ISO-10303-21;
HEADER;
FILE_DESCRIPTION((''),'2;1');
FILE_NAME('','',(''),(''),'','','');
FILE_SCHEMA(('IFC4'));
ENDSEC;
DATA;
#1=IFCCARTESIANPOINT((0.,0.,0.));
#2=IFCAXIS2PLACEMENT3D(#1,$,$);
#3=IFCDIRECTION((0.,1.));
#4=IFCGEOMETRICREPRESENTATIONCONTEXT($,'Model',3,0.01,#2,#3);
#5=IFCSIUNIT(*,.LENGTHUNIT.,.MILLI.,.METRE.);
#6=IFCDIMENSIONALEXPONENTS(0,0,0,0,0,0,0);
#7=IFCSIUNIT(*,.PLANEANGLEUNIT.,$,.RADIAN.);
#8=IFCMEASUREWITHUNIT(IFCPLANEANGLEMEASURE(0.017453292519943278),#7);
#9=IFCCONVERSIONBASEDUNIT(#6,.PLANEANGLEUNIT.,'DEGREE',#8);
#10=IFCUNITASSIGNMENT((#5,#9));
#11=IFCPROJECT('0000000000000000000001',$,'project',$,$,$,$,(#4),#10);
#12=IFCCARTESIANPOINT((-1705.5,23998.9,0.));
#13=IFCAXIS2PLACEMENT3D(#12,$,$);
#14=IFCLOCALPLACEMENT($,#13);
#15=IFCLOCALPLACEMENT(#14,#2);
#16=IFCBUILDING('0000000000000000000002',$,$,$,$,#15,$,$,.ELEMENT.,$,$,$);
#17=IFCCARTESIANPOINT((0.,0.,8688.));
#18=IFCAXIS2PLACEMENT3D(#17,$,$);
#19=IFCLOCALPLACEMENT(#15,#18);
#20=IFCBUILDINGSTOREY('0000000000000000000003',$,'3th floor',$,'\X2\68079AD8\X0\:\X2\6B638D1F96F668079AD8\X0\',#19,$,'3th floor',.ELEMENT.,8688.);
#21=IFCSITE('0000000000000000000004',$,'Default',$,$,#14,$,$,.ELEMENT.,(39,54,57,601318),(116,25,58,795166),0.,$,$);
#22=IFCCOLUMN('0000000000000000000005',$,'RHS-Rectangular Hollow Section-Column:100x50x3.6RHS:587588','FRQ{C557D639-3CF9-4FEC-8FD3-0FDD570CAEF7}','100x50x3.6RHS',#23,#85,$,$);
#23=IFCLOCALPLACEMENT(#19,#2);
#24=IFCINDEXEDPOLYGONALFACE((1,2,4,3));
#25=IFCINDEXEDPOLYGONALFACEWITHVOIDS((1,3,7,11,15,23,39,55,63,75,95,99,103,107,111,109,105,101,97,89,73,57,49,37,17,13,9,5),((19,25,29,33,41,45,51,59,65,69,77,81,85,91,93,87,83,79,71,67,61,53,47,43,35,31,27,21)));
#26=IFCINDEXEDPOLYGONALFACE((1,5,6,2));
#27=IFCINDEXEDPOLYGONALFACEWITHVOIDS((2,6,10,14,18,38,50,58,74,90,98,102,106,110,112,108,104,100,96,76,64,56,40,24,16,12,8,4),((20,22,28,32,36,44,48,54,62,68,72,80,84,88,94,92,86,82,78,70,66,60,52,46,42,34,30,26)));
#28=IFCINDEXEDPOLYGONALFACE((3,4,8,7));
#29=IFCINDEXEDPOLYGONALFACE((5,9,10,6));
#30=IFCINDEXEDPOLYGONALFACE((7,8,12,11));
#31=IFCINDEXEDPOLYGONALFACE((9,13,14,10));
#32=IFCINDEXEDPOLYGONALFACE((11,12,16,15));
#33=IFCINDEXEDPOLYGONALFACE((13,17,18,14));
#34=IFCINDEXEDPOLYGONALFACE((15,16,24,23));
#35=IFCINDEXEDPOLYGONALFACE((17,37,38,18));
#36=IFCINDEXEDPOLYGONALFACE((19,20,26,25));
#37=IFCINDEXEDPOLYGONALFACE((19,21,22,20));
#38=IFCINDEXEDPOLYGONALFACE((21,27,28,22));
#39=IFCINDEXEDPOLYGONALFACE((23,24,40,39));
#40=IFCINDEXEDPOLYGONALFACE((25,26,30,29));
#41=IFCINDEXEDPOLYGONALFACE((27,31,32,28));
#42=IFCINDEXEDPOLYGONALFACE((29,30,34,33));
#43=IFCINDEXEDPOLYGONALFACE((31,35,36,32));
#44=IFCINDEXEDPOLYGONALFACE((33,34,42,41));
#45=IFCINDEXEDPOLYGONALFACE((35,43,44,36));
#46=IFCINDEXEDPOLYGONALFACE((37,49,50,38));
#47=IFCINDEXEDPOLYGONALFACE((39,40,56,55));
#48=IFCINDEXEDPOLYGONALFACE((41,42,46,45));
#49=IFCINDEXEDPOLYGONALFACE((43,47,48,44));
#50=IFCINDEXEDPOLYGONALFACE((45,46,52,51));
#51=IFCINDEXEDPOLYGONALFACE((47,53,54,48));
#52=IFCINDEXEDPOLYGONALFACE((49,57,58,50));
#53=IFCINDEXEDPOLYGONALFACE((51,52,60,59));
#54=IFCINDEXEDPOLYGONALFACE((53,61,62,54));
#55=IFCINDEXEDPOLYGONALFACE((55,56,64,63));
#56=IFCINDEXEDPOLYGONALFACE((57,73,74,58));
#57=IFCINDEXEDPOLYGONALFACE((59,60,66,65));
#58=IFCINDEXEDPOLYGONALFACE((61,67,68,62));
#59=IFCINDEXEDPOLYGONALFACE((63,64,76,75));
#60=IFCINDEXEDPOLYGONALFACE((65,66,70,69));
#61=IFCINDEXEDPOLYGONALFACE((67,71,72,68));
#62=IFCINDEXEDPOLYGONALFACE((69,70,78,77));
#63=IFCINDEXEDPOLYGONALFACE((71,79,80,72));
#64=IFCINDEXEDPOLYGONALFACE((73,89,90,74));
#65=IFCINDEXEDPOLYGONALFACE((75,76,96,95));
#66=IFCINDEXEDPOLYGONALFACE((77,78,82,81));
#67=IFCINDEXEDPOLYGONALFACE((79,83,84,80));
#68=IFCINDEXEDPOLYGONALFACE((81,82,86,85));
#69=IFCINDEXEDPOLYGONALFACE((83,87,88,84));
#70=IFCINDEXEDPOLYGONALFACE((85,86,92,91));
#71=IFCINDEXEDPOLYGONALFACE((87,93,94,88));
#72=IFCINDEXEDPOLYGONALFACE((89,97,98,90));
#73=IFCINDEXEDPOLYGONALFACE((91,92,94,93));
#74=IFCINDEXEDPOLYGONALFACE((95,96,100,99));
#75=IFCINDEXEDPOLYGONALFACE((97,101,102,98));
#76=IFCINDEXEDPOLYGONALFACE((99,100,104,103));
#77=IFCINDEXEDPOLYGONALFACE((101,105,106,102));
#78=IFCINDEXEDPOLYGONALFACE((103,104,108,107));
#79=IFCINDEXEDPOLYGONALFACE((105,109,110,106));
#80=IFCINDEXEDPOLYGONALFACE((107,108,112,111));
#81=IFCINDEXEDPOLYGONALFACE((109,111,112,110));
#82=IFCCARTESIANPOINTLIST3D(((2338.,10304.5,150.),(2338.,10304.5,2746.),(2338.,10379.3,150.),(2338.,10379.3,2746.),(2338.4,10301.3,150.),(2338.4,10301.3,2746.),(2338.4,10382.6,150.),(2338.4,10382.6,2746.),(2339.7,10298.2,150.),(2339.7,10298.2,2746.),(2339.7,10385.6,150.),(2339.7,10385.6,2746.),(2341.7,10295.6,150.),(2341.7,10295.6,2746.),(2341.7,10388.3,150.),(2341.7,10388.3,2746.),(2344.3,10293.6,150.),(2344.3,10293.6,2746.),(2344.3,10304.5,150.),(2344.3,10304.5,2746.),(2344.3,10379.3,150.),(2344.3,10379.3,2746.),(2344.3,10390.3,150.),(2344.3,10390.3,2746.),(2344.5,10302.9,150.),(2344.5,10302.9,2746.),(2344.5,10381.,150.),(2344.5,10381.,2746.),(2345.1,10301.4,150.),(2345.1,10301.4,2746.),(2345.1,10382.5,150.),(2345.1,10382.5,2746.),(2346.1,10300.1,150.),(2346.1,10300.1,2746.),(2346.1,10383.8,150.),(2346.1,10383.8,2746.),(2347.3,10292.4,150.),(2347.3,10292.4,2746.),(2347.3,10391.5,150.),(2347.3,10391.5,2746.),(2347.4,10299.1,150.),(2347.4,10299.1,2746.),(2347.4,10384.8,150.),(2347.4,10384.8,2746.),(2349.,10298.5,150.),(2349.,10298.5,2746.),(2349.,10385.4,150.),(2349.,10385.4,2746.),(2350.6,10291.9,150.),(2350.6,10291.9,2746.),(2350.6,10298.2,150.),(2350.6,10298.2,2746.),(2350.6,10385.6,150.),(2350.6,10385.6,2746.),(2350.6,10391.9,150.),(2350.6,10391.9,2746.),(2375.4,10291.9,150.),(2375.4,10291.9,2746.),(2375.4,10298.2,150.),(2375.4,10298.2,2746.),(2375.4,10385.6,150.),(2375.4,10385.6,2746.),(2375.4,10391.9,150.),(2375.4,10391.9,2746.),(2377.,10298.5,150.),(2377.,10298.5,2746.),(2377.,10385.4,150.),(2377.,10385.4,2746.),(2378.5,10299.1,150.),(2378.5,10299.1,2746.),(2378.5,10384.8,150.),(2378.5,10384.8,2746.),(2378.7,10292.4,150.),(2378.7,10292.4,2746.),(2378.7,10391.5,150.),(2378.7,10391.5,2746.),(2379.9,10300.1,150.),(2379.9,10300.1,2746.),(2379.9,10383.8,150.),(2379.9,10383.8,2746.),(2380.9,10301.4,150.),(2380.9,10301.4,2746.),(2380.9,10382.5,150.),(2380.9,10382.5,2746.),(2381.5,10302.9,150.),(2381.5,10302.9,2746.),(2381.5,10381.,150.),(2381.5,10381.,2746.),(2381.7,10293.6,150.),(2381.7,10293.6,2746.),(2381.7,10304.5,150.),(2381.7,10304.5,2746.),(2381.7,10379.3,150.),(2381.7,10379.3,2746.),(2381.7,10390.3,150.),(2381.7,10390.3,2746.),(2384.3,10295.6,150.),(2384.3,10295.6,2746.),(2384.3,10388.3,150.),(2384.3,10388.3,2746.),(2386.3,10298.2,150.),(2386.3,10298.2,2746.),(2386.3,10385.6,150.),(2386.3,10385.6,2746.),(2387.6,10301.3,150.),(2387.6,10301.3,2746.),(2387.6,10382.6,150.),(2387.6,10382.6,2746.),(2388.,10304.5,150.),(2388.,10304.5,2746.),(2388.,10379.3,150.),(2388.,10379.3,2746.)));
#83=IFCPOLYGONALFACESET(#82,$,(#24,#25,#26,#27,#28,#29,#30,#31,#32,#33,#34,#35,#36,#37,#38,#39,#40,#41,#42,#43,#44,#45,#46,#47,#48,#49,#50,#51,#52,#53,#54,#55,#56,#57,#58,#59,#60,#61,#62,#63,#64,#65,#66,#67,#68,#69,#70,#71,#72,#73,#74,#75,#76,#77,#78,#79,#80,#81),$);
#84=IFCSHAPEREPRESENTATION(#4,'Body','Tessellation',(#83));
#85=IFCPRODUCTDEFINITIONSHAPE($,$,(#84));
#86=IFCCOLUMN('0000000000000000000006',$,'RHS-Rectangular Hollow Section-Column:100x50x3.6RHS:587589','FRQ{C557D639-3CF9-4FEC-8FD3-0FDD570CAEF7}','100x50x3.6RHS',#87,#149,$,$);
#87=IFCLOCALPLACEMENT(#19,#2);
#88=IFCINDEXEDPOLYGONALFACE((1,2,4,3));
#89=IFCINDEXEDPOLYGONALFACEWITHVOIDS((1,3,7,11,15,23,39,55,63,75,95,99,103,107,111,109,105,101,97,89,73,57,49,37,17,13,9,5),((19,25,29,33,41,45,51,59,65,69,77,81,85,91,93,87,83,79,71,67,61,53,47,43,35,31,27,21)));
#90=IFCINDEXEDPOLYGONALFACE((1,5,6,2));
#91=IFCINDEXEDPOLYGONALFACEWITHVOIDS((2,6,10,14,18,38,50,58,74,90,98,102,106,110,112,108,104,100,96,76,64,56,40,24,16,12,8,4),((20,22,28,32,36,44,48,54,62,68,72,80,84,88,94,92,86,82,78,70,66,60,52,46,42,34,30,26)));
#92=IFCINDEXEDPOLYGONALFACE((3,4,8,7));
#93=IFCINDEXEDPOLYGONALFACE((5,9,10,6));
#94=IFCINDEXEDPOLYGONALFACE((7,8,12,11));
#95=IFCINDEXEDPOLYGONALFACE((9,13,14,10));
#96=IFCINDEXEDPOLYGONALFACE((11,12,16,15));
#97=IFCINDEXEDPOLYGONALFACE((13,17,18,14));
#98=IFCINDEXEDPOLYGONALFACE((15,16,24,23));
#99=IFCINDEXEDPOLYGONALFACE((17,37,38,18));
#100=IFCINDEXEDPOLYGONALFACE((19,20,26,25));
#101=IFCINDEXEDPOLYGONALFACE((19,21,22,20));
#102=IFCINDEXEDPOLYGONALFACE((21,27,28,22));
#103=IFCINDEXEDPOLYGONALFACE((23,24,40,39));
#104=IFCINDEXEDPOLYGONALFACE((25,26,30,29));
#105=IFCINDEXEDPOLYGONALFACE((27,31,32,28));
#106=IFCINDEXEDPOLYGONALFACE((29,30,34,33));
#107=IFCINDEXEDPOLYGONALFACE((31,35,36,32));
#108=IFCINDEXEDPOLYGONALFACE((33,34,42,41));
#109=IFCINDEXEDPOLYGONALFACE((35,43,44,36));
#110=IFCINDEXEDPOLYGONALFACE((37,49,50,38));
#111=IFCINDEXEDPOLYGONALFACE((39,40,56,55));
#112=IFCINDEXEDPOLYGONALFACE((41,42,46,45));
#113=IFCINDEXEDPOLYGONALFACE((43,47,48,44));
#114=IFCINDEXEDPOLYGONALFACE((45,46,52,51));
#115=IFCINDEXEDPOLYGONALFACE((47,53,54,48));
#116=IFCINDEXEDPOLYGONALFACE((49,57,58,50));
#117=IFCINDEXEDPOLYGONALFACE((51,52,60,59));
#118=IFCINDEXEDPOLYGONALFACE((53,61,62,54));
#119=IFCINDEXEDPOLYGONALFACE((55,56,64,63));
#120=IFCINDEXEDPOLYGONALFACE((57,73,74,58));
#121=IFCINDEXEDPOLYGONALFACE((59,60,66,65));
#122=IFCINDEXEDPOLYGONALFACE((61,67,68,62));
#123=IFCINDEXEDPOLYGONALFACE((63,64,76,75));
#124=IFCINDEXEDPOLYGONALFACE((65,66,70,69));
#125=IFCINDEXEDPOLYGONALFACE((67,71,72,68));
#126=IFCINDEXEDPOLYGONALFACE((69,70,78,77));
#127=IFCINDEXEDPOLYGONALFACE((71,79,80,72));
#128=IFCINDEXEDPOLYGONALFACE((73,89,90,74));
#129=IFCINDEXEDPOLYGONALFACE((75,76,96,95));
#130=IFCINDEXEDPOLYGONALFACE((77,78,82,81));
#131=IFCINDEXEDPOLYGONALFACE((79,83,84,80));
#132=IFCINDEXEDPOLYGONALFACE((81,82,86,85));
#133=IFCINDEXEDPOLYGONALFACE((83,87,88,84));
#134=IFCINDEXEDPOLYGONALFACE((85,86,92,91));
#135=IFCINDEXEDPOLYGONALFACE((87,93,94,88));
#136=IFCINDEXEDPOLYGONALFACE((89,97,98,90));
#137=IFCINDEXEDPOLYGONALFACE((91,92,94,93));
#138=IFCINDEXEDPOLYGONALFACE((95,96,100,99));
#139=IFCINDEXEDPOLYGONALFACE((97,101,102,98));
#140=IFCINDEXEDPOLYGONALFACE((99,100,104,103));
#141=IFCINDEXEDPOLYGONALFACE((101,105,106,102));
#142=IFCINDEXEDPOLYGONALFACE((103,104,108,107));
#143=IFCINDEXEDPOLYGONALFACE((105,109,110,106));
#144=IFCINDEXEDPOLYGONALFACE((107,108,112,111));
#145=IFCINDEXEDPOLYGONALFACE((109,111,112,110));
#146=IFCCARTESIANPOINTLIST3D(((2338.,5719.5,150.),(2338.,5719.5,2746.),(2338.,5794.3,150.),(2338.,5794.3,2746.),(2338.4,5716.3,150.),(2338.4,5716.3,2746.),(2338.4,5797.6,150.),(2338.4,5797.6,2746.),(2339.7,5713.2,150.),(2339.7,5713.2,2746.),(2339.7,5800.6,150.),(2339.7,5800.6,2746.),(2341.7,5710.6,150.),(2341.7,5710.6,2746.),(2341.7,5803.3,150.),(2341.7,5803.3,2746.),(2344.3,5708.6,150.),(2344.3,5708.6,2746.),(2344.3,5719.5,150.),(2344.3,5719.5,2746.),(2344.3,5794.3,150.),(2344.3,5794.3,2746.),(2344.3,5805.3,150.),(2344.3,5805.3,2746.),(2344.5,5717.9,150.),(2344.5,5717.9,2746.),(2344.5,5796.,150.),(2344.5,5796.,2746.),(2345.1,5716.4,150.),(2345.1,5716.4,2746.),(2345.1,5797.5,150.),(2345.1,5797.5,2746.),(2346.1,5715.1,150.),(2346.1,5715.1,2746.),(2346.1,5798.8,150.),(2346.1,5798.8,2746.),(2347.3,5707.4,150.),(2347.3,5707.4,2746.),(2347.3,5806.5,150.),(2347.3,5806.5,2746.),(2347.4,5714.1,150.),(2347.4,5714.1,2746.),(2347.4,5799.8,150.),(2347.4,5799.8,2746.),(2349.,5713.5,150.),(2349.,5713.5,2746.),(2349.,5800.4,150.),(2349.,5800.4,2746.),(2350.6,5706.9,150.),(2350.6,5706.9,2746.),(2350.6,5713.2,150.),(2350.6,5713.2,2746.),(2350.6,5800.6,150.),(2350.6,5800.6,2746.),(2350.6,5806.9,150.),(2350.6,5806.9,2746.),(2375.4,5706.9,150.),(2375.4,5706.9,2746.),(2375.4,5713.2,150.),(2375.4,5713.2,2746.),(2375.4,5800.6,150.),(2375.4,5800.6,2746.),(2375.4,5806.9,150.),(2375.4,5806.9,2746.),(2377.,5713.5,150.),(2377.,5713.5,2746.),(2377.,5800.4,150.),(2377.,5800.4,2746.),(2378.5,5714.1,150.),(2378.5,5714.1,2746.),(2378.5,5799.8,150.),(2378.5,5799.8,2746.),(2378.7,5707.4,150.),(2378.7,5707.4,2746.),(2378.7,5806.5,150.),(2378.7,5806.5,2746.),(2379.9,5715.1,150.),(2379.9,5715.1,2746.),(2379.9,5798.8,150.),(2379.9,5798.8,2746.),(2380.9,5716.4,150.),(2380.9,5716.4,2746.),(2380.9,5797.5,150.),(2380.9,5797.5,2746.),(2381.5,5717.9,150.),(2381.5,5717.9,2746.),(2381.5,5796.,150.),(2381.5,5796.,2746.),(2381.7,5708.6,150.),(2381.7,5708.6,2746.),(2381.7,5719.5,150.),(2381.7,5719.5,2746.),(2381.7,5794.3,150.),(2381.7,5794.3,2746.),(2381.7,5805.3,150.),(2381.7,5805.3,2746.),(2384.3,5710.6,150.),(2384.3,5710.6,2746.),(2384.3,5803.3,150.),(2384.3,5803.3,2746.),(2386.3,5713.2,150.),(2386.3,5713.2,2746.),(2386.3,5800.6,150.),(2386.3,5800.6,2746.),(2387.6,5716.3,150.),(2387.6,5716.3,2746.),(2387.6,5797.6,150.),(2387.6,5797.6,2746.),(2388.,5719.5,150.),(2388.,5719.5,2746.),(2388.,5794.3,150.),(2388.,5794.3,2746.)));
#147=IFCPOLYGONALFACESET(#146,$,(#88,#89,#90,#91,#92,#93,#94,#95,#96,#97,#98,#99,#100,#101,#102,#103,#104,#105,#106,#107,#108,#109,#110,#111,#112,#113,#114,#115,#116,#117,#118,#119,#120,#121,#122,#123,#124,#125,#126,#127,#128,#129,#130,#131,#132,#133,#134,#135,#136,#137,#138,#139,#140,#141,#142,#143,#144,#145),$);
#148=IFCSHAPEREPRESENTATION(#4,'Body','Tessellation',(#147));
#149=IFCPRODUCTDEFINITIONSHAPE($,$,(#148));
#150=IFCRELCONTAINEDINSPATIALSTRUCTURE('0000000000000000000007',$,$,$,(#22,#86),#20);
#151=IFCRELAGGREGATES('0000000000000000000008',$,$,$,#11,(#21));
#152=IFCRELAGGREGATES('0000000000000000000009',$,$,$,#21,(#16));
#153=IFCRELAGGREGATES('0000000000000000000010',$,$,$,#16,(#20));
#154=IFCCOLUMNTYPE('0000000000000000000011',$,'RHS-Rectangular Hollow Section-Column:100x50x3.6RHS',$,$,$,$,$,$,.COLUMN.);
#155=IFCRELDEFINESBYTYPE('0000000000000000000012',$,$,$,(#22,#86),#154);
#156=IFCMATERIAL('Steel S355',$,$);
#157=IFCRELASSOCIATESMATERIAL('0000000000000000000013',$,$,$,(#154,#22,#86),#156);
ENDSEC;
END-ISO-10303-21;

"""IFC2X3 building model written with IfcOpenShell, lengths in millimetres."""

from ifc_helpers import new_model, entity, si_unit, converted_unit, direction, frame, origin, origin_2d, place, context, project, spatial, hollow_rectangle, extrude, clip, halfspace, material, type_object, element, save


model = new_model("IFC2X3")

# Units and contexts
model_context = context("Model", 3, precision=0.01, world=origin(), true_north=direction((0.0, 1.0)))
ifc_project = project(units=[si_unit("LENGTHUNIT", "METRE", prefix="MILLI"), converted_unit("PLANEANGLEUNIT", "DEGREE", entity("IfcPlaneAngleMeasure", 0.017453292519943278), si_unit("PLANEANGLEUNIT", "RADIAN"), dimensions=[0, 0, 0, 0, 0, 0, 0])], contexts=[model_context])

# Site, building, storey
site_placement = place(None, frame((-1705.5, 23998.9, 0.0)))
site = spatial("IfcSite", under=ifc_project, at=site_placement, Name="Default", CompositionType="ELEMENT", RefLatitude=(39, 54, 57, 601318), RefLongitude=(116, 25, 58, 795166), RefElevation=0.0)
building_placement = place(site_placement, origin())
building = spatial("IfcBuilding", under=site, at=building_placement, CompositionType="ELEMENT")
storey_placement = place(building_placement, frame((0.0, 0.0, 8688.0)))
storey = spatial("IfcBuildingStorey", under=building, at=storey_placement, Name="3th floor", ObjectType="标高:正负零标高", LongName="3th floor", CompositionType="ELEMENT", Elevation=8688.0)

# Columns
ifc_material_1 = material(Name="Steel S355")
column_type_1 = type_object("IfcColumnType", Name="RHS-Rectangular Hollow Section-Column:100x50x3.6RHS", PredefinedType="COLUMN", material=ifc_material_1)
column_1_placement = place(storey_placement, frame((2363.0, 10341.9, 2746.0)))
element("IfcColumn", 1, at=column_1_placement, inside=storey, type_object=column_type_1, material=ifc_material_1, Name="RHS-Rectangular Hollow Section-Column:100x50x3.6RHS:587588", Description="FRQ{C557D639-3CF9-4FEC-8FD3-0FDD570CAEF7}", ObjectType="100x50x3.6RHS", context=model_context, shape_type="Clipping", body=[
    clip(extrude(hollow_rectangle(XDim=50.0, YDim=100.0, WallThickness=6.3, InnerFilletRadius=6.3, OuterFilletRadius=12.6, at=origin_2d()), origin(), (0.0, 0.0, -1.0), 2651.9), halfspace(frame((-2363.0, -10341.9, -2596.0), z_axis=(0.0, 0.0, 1.0), x_axis=(1.0, 0.0, 0.0)), True)),
])
column_2_placement = place(storey_placement, frame((2363.0, 5756.9, 2746.0)))
element("IfcColumn", 2, at=column_2_placement, inside=storey, type_object=column_type_1, material=ifc_material_1, Name="RHS-Rectangular Hollow Section-Column:100x50x3.6RHS:587589", Description="FRQ{C557D639-3CF9-4FEC-8FD3-0FDD570CAEF7}", ObjectType="100x50x3.6RHS", context=model_context, shape_type="Clipping", body=[
    clip(extrude(hollow_rectangle(XDim=50.0, YDim=100.0, WallThickness=6.3, InnerFilletRadius=6.3, OuterFilletRadius=12.6, at=origin_2d()), origin(), (0.0, 0.0, -1.0), 2651.9), halfspace(frame((-2363.0, -5756.9, -2596.0), z_axis=(0.0, 0.0, 1.0), x_axis=(1.0, 0.0, 0.0)), True)),
])

save(model, "model.ifc")
